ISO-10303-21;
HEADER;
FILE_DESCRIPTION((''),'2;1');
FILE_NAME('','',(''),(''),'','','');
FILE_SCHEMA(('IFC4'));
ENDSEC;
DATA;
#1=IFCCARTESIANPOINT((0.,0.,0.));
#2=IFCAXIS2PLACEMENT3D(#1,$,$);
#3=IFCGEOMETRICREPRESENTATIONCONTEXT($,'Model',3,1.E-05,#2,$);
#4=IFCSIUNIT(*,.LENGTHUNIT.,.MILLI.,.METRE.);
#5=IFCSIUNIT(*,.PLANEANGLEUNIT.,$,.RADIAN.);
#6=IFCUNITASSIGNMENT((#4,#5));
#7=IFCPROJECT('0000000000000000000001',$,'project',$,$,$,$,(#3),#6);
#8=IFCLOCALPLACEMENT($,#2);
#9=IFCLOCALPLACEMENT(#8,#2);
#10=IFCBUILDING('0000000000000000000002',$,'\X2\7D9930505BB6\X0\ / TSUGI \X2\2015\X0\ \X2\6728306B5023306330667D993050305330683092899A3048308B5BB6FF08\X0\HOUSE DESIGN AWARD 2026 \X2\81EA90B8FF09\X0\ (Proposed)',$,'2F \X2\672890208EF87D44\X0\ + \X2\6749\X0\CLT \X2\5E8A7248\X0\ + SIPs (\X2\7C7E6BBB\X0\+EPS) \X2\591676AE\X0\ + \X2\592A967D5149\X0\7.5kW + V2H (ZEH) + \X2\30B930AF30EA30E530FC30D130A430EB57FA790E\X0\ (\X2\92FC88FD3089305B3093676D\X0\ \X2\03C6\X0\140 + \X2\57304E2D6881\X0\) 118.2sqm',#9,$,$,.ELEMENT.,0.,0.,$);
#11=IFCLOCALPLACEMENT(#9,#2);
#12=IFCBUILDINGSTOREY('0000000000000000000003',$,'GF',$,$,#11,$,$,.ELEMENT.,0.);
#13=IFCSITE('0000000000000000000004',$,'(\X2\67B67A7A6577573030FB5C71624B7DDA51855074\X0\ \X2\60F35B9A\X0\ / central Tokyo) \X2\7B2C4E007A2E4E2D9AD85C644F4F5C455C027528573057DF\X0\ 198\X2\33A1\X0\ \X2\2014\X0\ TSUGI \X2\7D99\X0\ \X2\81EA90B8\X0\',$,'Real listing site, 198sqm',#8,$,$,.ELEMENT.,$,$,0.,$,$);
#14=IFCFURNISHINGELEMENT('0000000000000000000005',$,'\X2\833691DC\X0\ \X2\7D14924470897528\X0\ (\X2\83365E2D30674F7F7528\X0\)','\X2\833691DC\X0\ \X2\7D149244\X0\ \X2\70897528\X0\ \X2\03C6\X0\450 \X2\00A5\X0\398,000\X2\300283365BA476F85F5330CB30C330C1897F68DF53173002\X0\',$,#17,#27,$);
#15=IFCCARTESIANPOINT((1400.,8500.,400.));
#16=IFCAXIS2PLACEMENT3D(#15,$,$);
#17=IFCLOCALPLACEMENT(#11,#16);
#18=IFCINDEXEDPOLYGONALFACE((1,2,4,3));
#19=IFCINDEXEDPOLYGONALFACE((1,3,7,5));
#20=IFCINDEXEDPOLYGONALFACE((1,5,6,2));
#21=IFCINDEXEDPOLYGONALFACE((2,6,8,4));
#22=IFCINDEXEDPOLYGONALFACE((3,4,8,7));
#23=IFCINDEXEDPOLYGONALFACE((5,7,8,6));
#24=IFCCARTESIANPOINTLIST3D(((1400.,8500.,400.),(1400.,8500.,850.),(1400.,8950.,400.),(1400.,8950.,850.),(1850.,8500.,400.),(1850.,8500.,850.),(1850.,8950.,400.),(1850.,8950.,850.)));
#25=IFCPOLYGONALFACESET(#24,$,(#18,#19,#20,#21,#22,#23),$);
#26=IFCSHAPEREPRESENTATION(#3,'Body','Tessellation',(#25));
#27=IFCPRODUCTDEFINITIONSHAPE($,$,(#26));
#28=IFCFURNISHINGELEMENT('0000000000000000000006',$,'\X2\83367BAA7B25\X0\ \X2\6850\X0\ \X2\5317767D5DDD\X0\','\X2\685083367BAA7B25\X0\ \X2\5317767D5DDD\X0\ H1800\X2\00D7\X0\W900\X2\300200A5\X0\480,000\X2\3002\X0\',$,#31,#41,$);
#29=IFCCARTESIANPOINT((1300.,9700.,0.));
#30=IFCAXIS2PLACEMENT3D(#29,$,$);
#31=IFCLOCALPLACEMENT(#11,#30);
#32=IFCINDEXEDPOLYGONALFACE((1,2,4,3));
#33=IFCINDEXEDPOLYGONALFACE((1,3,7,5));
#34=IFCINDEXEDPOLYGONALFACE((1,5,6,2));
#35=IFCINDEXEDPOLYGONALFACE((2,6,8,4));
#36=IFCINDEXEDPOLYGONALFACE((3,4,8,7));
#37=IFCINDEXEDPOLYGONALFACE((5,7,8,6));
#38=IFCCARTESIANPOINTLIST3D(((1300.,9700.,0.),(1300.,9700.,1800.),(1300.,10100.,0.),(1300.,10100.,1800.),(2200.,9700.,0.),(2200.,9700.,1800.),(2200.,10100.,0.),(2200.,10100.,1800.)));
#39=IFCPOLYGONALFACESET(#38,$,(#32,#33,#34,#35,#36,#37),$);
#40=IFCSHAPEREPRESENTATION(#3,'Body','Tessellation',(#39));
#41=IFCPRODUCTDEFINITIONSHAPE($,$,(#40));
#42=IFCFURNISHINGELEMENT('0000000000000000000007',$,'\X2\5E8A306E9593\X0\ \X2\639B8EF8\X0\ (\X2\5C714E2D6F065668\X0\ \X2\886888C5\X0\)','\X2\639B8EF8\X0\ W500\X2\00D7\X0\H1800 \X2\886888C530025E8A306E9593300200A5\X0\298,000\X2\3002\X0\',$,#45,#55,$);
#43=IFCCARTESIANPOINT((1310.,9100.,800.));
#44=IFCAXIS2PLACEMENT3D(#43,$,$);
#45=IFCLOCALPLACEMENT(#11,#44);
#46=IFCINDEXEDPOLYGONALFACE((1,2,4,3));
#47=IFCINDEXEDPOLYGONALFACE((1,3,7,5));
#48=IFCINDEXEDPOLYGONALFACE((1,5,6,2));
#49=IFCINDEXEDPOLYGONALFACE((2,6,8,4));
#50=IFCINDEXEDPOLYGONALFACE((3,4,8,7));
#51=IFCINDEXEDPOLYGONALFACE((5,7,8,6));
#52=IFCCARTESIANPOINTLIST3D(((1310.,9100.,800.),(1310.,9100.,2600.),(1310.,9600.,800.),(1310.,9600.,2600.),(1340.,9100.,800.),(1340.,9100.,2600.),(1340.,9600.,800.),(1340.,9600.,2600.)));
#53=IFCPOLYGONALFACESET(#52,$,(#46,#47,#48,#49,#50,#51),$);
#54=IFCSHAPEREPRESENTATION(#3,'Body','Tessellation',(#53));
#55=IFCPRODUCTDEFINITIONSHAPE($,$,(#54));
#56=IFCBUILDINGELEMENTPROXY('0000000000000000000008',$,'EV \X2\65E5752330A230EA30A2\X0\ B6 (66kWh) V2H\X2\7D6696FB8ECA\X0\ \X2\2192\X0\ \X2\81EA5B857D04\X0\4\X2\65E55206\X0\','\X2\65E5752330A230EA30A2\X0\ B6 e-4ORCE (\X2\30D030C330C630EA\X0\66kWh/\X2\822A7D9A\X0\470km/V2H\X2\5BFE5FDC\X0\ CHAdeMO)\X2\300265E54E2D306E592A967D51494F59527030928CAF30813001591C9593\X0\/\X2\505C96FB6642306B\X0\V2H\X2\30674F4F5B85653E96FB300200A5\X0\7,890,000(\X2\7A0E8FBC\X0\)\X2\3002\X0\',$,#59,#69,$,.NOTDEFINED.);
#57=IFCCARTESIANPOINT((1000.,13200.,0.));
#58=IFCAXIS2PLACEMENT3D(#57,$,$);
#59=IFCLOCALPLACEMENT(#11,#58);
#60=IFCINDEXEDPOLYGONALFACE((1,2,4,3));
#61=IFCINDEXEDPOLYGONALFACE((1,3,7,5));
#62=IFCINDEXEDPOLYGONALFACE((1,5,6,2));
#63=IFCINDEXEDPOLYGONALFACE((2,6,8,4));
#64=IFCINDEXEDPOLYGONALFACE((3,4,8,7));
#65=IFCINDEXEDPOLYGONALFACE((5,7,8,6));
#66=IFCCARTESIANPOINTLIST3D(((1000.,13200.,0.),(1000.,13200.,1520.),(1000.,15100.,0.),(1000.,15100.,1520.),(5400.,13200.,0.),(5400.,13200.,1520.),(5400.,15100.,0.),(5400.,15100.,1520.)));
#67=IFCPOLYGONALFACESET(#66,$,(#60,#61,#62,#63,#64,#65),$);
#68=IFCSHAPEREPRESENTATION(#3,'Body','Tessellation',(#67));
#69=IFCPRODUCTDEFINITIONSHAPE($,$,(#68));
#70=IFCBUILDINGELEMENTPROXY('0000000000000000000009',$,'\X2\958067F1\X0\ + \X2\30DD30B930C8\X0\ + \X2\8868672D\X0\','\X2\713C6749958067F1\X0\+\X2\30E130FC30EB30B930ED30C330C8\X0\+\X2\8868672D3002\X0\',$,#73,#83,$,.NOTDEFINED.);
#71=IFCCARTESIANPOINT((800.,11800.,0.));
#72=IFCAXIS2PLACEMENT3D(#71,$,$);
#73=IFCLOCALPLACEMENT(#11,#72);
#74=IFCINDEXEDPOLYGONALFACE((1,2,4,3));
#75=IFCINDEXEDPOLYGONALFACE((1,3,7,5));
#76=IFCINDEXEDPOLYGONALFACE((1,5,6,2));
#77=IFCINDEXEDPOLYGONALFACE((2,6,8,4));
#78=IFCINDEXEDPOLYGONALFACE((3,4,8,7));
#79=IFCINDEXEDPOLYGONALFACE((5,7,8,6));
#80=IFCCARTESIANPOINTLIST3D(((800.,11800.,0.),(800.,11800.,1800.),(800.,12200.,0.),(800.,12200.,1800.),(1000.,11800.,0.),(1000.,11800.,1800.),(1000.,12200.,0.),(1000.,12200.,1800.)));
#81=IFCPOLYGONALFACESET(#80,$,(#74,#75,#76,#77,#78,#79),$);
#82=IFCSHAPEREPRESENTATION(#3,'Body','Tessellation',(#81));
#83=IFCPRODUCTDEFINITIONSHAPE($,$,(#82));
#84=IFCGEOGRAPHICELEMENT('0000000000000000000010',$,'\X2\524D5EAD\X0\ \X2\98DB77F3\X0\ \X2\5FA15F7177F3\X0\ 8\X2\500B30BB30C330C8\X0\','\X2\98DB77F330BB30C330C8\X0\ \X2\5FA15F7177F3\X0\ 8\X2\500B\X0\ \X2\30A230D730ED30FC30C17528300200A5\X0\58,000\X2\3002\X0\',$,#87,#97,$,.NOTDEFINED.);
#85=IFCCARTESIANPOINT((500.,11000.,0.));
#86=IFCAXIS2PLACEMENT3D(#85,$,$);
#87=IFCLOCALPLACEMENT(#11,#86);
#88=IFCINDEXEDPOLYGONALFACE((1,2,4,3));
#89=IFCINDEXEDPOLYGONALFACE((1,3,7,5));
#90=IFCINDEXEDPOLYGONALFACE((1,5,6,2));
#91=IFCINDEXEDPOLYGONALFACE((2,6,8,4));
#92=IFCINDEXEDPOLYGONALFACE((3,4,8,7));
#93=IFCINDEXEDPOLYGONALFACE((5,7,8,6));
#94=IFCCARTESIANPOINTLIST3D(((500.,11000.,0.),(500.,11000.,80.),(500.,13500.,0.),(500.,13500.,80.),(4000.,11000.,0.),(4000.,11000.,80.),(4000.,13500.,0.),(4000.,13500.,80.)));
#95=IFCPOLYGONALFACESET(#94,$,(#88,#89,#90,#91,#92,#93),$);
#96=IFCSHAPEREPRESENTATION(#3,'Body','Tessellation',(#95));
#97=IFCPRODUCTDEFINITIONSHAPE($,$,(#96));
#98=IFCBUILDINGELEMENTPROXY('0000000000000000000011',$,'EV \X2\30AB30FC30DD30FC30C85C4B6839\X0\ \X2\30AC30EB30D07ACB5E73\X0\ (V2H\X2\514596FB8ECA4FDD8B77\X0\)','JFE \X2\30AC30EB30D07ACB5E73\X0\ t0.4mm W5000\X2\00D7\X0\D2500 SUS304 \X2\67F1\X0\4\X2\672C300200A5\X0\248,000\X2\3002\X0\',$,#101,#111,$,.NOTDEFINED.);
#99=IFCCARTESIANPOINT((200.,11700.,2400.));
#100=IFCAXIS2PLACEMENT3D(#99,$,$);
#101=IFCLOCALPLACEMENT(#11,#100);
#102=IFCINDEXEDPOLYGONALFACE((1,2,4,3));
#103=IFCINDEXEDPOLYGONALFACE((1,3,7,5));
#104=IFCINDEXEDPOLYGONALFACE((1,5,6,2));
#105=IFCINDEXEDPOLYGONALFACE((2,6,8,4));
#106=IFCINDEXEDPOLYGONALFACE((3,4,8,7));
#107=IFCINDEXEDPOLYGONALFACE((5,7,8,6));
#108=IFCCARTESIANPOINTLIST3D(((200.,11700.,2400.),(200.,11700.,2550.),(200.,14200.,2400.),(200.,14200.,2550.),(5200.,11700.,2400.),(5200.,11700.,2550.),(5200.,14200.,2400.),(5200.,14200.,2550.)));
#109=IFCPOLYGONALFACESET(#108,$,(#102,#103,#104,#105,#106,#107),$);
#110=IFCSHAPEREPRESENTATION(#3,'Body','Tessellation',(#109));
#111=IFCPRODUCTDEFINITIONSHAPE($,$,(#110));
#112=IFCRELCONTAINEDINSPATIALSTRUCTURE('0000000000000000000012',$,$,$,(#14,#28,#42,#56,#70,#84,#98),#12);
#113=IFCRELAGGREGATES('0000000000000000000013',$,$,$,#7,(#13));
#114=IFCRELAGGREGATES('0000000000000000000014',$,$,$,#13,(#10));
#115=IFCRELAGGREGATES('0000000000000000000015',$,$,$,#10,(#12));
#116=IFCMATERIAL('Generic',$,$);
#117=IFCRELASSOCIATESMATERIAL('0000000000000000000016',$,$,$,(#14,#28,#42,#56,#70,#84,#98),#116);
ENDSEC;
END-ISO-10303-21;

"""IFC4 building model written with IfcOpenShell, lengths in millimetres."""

from ifc_helpers import new_model, si_unit, frame, frame_2d, origin, place, context, project, spatial, rectangle, extrude, material, element, save


model = new_model("IFC4")

# Units and contexts
model_context = context("Model", 3, precision=1e-05, world=origin())
ifc_project = project(units=[si_unit("LENGTHUNIT", "METRE", prefix="MILLI"), si_unit("PLANEANGLEUNIT", "RADIAN")], contexts=[model_context])

# Site, building, storey
site_placement = place(None, origin())
site = spatial("IfcSite", under=ifc_project, at=site_placement, Name="(架空敷地・山手線内側 想定 / central Tokyo) 第一種中高層住居専用地域 198㎡ — TSUGI 継 自邸", ObjectType="Real listing site, 198sqm", CompositionType="ELEMENT", RefElevation=0.0)
building_placement = place(site_placement, origin())
building = spatial("IfcBuilding", under=site, at=building_placement, Name="継ぐ家 / TSUGI ― 木に倣って継ぐことを覚える家（HOUSE DESIGN AWARD 2026 自邸） (Proposed)", ObjectType="2F 木造軸組 + 杉CLT 床版 + SIPs (籾殻+EPS) 外皮 + 太陽光7.5kW + V2H (ZEH) + スクリューパイル基礎 (鋼製らせん杭 φ140 + 地中梁) 118.2sqm", CompositionType="ELEMENT", ElevationOfRefHeight=0.0, ElevationOfTerrain=0.0)
storey_placement = place(building_placement, origin())
storey = spatial("IfcBuildingStorey", under=building, at=storey_placement, Name="GF", CompositionType="ELEMENT", Elevation=0.0)

# Shared definitions
ifc_material_1 = material(Name="Generic")

# Furnishing elements
furnishing_1_placement = place(storey_placement, frame((1400.0, 8500.0, 400.0)))
element("IfcFurnishingElement", 1, at=furnishing_1_placement, inside=storey, material=ifc_material_1, Name="茶釜 純鉄炉用 (茶席で使用)", Description="茶釜 純鉄 炉用 φ450 ¥398,000。茶室相当ニッチ西棟北。", context=model_context, shape_type="SweptSolid", body=[
    extrude(rectangle(XDim=450.0, YDim=450.0, at=frame_2d((225.0, 225.0))), frame((1400.0, 8500.0, 400.0)), (0.0, 0.0, 1.0), 450.0),
])
furnishing_2_placement = place(storey_placement, frame((1300.0, 9700.0, 0.0)))
element("IfcFurnishingElement", 2, at=furnishing_2_placement, inside=storey, material=ifc_material_1, Name="茶箪笥 桐 北白川", Description="桐茶箪笥 北白川 H1800×W900。¥480,000。", context=model_context, shape_type="SweptSolid", body=[
    extrude(rectangle(XDim=900.0, YDim=400.0, at=frame_2d((450.0, 200.0))), frame((1300.0, 9700.0, 0.0)), (0.0, 0.0, 1.0), 1800.0),
])
furnishing_3_placement = place(storey_placement, frame((1310.0, 9100.0, 800.0)))
element("IfcFurnishingElement", 3, at=furnishing_3_placement, inside=storey, material=ifc_material_1, Name="床の間 掛軸 (山中漆器 表装)", Description="掛軸 W500×H1800 表装。床の間。¥298,000。", context=model_context, shape_type="SweptSolid", body=[
    extrude(rectangle(XDim=30.0, YDim=500.0, at=frame_2d((15.0, 250.0))), frame((1310.0, 9100.0, 800.0)), (0.0, 0.0, 1.0), 1800.0),
])

# Building element proxies
proxy_1_placement = place(storey_placement, frame((1000.0, 13200.0, 0.0)))
element("IfcBuildingElementProxy", 4, at=proxy_1_placement, inside=storey, material=ifc_material_1, Name="EV 日産アリア B6 (66kWh) V2H給電車 → 自宅約4日分", Description="日産アリア B6 e-4ORCE (バッテリ66kWh/航続470km/V2H対応 CHAdeMO)。日中の太陽光余剰を貯め、夜間/停電時にV2Hで住宅放電。¥7,890,000(税込)。", PredefinedType="NOTDEFINED", context=model_context, shape_type="SweptSolid", body=[
    extrude(rectangle(XDim=4400.0, YDim=1900.0, at=frame_2d((2200.0, 950.0))), frame((1000.0, 13200.0, 0.0)), (0.0, 0.0, 1.0), 1520.0),
])
proxy_2_placement = place(storey_placement, frame((800.0, 11800.0, 0.0)))
element("IfcBuildingElementProxy", 5, at=proxy_2_placement, inside=storey, material=ifc_material_1, Name="門柱 + ポスト + 表札", Description="焼杉門柱+メールスロット+表札。", PredefinedType="NOTDEFINED", context=model_context, shape_type="SweptSolid", body=[
    extrude(rectangle(XDim=200.0, YDim=400.0, at=frame_2d((100.0, 200.0))), frame((800.0, 11800.0, 0.0)), (0.0, 0.0, 1.0), 1800.0),
])

# Geographic element
geographic_element_1_placement = place(storey_placement, frame((500.0, 11000.0, 0.0)))
element("IfcGeographicElement", 6, at=geographic_element_1_placement, inside=storey, material=ifc_material_1, Name="前庭 飛石 御影石 8個セット", Description="飛石セット 御影石 8個 アプローチ用。¥58,000。", PredefinedType="NOTDEFINED", context=model_context, shape_type="SweptSolid", body=[
    extrude(rectangle(XDim=3500.0, YDim=2500.0, at=frame_2d((1750.0, 1250.0))), frame((500.0, 11000.0, 0.0)), (0.0, 0.0, 1.0), 80.0),
])

# Building element proxy
proxy_3_placement = place(storey_placement, frame((200.0, 11700.0, 2400.0)))
element("IfcBuildingElementProxy", 7, at=proxy_3_placement, inside=storey, material=ifc_material_1, Name="EV カーポート屋根 ガルバ立平 (V2H充電車保護)", Description="JFE ガルバ立平 t0.4mm W5000×D2500 SUS304 柱4本。¥248,000。", PredefinedType="NOTDEFINED", context=model_context, shape_type="SweptSolid", body=[
    extrude(rectangle(XDim=5000.0, YDim=2500.0, at=frame_2d((2500.0, 1250.0))), frame((200.0, 11700.0, 2400.0)), (0.0, 0.0, 1.0), 150.0),
])

save(model, "model.ifc")
